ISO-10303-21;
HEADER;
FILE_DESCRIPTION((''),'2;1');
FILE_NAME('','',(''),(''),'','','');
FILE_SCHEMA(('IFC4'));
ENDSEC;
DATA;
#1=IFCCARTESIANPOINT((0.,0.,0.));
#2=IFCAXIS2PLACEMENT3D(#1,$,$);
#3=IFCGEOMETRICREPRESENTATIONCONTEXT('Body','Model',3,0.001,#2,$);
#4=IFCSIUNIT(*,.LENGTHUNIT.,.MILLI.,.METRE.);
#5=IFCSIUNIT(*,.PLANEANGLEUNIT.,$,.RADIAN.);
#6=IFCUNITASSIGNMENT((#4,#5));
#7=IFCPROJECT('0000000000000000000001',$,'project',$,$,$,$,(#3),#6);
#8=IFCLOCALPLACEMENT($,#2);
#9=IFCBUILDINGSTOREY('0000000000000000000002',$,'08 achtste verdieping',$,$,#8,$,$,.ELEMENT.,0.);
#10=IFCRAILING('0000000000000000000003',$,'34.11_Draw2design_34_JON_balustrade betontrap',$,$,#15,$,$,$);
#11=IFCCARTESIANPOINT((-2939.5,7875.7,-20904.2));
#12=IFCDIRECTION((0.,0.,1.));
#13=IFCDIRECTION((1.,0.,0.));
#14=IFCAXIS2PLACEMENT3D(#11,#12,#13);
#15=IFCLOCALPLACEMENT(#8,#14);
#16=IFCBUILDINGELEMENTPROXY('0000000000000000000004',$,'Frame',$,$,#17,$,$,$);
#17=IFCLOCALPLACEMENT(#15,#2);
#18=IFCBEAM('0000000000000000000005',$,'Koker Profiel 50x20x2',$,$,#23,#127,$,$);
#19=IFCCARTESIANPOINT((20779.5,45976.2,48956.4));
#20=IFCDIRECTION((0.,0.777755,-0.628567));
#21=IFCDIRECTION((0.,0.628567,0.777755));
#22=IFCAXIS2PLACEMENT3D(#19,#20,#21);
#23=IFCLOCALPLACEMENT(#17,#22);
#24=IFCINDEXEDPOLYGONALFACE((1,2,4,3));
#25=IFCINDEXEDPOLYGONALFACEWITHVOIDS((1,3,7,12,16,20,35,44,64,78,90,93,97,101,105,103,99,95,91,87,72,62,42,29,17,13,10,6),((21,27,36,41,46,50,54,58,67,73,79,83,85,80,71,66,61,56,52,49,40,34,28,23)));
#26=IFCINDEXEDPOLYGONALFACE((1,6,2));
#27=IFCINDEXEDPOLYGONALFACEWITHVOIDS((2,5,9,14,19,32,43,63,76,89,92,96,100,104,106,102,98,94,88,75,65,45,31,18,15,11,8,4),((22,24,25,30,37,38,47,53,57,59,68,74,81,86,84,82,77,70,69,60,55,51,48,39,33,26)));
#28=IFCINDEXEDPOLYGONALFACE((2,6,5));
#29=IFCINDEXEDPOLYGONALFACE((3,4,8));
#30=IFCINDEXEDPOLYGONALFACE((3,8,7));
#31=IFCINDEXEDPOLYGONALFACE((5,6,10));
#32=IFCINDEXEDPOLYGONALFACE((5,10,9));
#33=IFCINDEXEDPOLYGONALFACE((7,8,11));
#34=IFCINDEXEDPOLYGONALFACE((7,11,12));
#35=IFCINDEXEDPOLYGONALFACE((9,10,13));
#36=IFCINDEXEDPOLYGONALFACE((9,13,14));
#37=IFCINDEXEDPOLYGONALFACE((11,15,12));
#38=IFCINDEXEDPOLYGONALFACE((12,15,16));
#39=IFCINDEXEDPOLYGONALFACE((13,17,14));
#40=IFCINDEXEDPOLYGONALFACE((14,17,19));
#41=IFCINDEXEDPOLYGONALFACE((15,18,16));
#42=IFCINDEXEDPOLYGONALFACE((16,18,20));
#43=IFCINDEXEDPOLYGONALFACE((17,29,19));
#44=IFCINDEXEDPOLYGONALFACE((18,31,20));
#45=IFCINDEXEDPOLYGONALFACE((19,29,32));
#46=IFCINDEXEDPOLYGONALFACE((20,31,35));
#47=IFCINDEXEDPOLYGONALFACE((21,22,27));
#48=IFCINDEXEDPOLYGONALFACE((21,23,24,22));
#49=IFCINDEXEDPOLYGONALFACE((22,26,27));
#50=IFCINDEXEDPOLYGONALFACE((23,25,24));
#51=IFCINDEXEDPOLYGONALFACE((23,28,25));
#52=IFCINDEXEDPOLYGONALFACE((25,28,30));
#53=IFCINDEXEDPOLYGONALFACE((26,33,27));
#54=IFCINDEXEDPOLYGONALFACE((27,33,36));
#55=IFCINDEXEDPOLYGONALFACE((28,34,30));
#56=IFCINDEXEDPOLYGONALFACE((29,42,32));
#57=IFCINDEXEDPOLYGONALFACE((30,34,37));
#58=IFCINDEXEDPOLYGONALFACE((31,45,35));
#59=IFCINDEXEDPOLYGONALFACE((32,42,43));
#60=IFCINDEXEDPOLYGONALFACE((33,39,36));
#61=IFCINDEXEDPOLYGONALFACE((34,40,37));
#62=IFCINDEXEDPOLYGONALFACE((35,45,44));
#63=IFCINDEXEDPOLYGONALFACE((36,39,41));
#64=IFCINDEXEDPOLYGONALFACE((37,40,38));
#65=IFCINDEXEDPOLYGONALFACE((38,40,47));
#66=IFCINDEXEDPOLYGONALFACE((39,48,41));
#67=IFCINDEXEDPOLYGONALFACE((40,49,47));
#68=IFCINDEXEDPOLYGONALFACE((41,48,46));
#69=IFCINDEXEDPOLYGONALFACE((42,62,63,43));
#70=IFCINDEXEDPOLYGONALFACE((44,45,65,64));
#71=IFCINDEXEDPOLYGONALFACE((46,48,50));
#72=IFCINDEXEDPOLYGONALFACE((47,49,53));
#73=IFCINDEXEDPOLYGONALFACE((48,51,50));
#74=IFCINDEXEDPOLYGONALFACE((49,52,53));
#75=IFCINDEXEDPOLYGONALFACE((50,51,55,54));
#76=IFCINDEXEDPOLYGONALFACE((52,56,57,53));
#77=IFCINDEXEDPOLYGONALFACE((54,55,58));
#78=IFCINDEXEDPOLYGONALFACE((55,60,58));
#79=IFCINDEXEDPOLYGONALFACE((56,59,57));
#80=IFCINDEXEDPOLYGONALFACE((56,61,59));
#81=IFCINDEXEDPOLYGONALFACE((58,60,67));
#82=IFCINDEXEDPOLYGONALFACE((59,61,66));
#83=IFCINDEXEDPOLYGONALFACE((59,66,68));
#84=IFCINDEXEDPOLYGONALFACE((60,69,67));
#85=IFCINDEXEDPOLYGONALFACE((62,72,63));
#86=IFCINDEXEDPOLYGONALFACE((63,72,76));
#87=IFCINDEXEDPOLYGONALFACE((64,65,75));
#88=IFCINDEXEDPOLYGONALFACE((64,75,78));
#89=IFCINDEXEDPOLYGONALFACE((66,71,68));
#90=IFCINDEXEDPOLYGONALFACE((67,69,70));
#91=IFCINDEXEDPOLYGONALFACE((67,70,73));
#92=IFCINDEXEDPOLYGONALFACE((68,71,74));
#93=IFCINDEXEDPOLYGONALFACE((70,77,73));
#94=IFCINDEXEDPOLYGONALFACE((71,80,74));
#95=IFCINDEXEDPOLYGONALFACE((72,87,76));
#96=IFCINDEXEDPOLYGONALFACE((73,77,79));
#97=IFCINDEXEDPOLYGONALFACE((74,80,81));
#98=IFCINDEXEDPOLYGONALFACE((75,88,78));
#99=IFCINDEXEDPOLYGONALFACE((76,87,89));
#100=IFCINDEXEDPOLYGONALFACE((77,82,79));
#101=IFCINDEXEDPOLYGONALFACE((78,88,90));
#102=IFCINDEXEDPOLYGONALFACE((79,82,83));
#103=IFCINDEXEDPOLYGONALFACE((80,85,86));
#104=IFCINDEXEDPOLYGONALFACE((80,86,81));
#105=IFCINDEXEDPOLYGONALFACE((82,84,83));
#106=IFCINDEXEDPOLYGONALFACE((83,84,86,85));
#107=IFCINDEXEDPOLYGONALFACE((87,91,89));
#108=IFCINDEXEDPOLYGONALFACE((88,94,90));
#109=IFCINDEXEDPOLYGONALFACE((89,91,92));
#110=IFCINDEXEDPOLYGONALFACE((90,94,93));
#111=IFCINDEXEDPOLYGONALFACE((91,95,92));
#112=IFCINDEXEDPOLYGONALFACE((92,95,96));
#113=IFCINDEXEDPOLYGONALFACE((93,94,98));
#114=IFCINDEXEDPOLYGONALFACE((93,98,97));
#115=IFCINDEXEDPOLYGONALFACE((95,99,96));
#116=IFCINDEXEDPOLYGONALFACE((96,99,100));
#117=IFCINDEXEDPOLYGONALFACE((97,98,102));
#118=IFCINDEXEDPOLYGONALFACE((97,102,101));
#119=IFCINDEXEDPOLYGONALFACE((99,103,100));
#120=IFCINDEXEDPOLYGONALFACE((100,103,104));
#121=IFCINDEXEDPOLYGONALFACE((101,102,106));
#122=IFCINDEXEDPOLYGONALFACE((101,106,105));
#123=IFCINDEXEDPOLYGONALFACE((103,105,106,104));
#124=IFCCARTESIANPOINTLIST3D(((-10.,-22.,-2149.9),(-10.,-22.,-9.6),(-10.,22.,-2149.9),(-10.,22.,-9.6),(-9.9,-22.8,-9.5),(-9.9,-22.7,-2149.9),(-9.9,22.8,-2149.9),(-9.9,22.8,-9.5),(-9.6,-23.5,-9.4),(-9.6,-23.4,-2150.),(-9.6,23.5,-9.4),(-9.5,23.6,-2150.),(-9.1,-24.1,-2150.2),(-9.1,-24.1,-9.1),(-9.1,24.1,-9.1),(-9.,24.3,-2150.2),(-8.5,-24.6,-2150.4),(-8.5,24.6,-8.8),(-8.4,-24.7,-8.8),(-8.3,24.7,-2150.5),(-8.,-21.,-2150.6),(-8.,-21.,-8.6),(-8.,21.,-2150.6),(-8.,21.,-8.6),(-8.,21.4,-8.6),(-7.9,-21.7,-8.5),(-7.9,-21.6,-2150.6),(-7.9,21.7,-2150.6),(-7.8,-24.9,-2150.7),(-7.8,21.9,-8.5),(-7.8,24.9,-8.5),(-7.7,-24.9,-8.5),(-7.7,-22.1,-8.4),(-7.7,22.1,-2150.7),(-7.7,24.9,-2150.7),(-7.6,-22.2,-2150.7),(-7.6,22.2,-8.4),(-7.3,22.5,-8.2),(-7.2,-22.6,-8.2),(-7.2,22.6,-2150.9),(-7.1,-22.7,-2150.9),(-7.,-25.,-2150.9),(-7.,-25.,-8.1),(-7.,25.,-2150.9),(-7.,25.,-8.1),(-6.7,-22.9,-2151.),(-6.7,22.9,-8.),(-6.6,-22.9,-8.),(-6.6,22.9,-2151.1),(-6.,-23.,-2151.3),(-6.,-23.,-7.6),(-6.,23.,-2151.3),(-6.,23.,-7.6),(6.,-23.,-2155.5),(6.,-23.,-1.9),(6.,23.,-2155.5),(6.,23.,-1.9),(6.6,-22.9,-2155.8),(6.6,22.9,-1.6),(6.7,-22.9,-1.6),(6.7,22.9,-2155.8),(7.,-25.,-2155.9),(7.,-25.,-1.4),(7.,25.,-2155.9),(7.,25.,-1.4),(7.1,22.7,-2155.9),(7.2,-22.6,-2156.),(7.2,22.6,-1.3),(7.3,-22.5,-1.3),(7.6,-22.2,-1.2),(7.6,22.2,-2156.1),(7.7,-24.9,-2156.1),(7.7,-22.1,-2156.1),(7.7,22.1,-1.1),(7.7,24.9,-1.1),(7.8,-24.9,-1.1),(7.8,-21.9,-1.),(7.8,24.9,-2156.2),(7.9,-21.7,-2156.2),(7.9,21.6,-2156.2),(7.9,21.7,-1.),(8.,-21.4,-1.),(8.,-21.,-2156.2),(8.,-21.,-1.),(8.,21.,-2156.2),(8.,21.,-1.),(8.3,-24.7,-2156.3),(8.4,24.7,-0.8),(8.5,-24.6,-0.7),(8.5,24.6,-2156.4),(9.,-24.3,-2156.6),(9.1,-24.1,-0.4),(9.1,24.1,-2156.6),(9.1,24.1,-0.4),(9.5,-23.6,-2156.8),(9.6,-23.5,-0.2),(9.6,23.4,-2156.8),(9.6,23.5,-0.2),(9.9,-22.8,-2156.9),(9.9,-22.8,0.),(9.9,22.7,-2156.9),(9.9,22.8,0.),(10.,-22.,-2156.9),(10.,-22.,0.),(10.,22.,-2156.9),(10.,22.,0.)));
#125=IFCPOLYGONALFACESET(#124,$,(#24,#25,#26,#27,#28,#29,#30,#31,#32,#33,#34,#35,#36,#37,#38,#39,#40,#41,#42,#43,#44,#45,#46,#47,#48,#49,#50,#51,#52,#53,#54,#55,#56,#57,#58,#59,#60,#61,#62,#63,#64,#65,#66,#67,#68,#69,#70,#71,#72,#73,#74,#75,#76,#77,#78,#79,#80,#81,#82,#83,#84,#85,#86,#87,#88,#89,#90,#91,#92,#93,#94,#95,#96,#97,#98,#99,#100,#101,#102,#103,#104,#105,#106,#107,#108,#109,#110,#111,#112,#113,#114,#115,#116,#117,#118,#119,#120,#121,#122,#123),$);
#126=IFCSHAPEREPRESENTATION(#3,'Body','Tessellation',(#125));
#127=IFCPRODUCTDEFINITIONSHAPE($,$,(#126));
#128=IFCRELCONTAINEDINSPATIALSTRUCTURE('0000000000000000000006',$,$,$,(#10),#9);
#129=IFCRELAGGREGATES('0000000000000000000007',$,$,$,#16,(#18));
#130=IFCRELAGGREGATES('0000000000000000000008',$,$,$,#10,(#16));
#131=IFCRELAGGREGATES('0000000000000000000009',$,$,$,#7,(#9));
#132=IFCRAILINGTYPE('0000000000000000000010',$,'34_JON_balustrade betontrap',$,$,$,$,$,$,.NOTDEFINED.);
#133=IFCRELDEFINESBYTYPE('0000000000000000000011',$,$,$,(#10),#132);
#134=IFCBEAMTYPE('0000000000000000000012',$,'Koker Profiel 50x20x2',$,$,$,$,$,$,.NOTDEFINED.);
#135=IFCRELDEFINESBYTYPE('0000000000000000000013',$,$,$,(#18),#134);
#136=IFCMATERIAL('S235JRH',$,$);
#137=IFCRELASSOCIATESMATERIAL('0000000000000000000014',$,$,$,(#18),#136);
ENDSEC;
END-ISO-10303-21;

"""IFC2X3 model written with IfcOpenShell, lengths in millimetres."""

from ifc_helpers import new_model, si_unit, frame, origin, origin_2d, place, context, project, spatial, hollow_rectangle, extrude, clip, halfspace, source, transform, mapped, material, type_object, element, aggregate, save


model = new_model("IFC2X3")

# Units and contexts
model_context = context("Model", 3, precision=0.001, world=origin(), identifier="Body")
ifc_project = project(units=[si_unit("LENGTHUNIT", "METRE", prefix="MILLI"), si_unit("PLANEANGLEUNIT", "RADIAN")], contexts=[model_context])

# Storey
storey_placement = place(None, origin())
storey = spatial("IfcBuildingStorey", under=ifc_project, at=storey_placement, Name="08 achtste verdieping", CompositionType="ELEMENT", Elevation=0.0)

# Railing, building element proxy, beam
railing_type = type_object("IfcRailingType", Name="34_JON_balustrade betontrap")
railing_1_placement = place(storey_placement, frame((-2939.5, 7875.7, -20904.2), z_axis=(0.0, 0.0, 1.0), x_axis=(1.0, 0.0, 0.0)))
railing_1 = element("IfcRailing", 1, at=railing_1_placement, inside=storey, type_object=railing_type, Name="34.11_Draw2design_34_JON_balustrade betontrap")
ifc_material_1 = material(Name="S235JRH")
proxy_1_placement = place(railing_1_placement, origin())
proxy_1 = element("IfcBuildingElementProxy", 2, at=proxy_1_placement, Name="Frame")
beam_type_1 = type_object("IfcBeamType", Name="Koker Profiel 50x20x2")
shared_shape_1 = source(origin(), model_context, "Body", "Clipping", [
    clip(clip(extrude(hollow_rectangle(XDim=20.0, YDim=50.0, WallThickness=2.0, InnerFilletRadius=2.0, OuterFilletRadius=3.0, at=origin_2d()), origin(), (0.0, 0.0, -1.0), 2156.9), halfspace(frame((-10.0, 25.0, -9.6), z_axis=(-0.430948, 0.0, 0.902377), x_axis=(-0.902377, 0.0, -0.430948)), False)), halfspace(frame((-10.0, -25.0, -2149.9), z_axis=(-0.33335, 0.0, -0.942803), x_axis=(0.0, -1.0, 0.0)), False)),
])
beam_1_placement = place(proxy_1_placement, frame((20779.5, 45976.2, 48956.4), z_axis=(0.0, 0.777755, -0.628567), x_axis=(0.0, 0.628567, 0.777755)))
beam_1 = element("IfcBeam", 3, at=beam_1_placement, type_object=beam_type_1, material=ifc_material_1, Name="Koker Profiel 50x20x2", context=model_context, shape_type="MappedRepresentation", body=[
    mapped(shared_shape_1, transform((0.0, 0.0, 0.0), scale=1.0)),
])

aggregate(proxy_1, [beam_1])

aggregate(railing_1, [proxy_1])

save(model, "model.ifc")
